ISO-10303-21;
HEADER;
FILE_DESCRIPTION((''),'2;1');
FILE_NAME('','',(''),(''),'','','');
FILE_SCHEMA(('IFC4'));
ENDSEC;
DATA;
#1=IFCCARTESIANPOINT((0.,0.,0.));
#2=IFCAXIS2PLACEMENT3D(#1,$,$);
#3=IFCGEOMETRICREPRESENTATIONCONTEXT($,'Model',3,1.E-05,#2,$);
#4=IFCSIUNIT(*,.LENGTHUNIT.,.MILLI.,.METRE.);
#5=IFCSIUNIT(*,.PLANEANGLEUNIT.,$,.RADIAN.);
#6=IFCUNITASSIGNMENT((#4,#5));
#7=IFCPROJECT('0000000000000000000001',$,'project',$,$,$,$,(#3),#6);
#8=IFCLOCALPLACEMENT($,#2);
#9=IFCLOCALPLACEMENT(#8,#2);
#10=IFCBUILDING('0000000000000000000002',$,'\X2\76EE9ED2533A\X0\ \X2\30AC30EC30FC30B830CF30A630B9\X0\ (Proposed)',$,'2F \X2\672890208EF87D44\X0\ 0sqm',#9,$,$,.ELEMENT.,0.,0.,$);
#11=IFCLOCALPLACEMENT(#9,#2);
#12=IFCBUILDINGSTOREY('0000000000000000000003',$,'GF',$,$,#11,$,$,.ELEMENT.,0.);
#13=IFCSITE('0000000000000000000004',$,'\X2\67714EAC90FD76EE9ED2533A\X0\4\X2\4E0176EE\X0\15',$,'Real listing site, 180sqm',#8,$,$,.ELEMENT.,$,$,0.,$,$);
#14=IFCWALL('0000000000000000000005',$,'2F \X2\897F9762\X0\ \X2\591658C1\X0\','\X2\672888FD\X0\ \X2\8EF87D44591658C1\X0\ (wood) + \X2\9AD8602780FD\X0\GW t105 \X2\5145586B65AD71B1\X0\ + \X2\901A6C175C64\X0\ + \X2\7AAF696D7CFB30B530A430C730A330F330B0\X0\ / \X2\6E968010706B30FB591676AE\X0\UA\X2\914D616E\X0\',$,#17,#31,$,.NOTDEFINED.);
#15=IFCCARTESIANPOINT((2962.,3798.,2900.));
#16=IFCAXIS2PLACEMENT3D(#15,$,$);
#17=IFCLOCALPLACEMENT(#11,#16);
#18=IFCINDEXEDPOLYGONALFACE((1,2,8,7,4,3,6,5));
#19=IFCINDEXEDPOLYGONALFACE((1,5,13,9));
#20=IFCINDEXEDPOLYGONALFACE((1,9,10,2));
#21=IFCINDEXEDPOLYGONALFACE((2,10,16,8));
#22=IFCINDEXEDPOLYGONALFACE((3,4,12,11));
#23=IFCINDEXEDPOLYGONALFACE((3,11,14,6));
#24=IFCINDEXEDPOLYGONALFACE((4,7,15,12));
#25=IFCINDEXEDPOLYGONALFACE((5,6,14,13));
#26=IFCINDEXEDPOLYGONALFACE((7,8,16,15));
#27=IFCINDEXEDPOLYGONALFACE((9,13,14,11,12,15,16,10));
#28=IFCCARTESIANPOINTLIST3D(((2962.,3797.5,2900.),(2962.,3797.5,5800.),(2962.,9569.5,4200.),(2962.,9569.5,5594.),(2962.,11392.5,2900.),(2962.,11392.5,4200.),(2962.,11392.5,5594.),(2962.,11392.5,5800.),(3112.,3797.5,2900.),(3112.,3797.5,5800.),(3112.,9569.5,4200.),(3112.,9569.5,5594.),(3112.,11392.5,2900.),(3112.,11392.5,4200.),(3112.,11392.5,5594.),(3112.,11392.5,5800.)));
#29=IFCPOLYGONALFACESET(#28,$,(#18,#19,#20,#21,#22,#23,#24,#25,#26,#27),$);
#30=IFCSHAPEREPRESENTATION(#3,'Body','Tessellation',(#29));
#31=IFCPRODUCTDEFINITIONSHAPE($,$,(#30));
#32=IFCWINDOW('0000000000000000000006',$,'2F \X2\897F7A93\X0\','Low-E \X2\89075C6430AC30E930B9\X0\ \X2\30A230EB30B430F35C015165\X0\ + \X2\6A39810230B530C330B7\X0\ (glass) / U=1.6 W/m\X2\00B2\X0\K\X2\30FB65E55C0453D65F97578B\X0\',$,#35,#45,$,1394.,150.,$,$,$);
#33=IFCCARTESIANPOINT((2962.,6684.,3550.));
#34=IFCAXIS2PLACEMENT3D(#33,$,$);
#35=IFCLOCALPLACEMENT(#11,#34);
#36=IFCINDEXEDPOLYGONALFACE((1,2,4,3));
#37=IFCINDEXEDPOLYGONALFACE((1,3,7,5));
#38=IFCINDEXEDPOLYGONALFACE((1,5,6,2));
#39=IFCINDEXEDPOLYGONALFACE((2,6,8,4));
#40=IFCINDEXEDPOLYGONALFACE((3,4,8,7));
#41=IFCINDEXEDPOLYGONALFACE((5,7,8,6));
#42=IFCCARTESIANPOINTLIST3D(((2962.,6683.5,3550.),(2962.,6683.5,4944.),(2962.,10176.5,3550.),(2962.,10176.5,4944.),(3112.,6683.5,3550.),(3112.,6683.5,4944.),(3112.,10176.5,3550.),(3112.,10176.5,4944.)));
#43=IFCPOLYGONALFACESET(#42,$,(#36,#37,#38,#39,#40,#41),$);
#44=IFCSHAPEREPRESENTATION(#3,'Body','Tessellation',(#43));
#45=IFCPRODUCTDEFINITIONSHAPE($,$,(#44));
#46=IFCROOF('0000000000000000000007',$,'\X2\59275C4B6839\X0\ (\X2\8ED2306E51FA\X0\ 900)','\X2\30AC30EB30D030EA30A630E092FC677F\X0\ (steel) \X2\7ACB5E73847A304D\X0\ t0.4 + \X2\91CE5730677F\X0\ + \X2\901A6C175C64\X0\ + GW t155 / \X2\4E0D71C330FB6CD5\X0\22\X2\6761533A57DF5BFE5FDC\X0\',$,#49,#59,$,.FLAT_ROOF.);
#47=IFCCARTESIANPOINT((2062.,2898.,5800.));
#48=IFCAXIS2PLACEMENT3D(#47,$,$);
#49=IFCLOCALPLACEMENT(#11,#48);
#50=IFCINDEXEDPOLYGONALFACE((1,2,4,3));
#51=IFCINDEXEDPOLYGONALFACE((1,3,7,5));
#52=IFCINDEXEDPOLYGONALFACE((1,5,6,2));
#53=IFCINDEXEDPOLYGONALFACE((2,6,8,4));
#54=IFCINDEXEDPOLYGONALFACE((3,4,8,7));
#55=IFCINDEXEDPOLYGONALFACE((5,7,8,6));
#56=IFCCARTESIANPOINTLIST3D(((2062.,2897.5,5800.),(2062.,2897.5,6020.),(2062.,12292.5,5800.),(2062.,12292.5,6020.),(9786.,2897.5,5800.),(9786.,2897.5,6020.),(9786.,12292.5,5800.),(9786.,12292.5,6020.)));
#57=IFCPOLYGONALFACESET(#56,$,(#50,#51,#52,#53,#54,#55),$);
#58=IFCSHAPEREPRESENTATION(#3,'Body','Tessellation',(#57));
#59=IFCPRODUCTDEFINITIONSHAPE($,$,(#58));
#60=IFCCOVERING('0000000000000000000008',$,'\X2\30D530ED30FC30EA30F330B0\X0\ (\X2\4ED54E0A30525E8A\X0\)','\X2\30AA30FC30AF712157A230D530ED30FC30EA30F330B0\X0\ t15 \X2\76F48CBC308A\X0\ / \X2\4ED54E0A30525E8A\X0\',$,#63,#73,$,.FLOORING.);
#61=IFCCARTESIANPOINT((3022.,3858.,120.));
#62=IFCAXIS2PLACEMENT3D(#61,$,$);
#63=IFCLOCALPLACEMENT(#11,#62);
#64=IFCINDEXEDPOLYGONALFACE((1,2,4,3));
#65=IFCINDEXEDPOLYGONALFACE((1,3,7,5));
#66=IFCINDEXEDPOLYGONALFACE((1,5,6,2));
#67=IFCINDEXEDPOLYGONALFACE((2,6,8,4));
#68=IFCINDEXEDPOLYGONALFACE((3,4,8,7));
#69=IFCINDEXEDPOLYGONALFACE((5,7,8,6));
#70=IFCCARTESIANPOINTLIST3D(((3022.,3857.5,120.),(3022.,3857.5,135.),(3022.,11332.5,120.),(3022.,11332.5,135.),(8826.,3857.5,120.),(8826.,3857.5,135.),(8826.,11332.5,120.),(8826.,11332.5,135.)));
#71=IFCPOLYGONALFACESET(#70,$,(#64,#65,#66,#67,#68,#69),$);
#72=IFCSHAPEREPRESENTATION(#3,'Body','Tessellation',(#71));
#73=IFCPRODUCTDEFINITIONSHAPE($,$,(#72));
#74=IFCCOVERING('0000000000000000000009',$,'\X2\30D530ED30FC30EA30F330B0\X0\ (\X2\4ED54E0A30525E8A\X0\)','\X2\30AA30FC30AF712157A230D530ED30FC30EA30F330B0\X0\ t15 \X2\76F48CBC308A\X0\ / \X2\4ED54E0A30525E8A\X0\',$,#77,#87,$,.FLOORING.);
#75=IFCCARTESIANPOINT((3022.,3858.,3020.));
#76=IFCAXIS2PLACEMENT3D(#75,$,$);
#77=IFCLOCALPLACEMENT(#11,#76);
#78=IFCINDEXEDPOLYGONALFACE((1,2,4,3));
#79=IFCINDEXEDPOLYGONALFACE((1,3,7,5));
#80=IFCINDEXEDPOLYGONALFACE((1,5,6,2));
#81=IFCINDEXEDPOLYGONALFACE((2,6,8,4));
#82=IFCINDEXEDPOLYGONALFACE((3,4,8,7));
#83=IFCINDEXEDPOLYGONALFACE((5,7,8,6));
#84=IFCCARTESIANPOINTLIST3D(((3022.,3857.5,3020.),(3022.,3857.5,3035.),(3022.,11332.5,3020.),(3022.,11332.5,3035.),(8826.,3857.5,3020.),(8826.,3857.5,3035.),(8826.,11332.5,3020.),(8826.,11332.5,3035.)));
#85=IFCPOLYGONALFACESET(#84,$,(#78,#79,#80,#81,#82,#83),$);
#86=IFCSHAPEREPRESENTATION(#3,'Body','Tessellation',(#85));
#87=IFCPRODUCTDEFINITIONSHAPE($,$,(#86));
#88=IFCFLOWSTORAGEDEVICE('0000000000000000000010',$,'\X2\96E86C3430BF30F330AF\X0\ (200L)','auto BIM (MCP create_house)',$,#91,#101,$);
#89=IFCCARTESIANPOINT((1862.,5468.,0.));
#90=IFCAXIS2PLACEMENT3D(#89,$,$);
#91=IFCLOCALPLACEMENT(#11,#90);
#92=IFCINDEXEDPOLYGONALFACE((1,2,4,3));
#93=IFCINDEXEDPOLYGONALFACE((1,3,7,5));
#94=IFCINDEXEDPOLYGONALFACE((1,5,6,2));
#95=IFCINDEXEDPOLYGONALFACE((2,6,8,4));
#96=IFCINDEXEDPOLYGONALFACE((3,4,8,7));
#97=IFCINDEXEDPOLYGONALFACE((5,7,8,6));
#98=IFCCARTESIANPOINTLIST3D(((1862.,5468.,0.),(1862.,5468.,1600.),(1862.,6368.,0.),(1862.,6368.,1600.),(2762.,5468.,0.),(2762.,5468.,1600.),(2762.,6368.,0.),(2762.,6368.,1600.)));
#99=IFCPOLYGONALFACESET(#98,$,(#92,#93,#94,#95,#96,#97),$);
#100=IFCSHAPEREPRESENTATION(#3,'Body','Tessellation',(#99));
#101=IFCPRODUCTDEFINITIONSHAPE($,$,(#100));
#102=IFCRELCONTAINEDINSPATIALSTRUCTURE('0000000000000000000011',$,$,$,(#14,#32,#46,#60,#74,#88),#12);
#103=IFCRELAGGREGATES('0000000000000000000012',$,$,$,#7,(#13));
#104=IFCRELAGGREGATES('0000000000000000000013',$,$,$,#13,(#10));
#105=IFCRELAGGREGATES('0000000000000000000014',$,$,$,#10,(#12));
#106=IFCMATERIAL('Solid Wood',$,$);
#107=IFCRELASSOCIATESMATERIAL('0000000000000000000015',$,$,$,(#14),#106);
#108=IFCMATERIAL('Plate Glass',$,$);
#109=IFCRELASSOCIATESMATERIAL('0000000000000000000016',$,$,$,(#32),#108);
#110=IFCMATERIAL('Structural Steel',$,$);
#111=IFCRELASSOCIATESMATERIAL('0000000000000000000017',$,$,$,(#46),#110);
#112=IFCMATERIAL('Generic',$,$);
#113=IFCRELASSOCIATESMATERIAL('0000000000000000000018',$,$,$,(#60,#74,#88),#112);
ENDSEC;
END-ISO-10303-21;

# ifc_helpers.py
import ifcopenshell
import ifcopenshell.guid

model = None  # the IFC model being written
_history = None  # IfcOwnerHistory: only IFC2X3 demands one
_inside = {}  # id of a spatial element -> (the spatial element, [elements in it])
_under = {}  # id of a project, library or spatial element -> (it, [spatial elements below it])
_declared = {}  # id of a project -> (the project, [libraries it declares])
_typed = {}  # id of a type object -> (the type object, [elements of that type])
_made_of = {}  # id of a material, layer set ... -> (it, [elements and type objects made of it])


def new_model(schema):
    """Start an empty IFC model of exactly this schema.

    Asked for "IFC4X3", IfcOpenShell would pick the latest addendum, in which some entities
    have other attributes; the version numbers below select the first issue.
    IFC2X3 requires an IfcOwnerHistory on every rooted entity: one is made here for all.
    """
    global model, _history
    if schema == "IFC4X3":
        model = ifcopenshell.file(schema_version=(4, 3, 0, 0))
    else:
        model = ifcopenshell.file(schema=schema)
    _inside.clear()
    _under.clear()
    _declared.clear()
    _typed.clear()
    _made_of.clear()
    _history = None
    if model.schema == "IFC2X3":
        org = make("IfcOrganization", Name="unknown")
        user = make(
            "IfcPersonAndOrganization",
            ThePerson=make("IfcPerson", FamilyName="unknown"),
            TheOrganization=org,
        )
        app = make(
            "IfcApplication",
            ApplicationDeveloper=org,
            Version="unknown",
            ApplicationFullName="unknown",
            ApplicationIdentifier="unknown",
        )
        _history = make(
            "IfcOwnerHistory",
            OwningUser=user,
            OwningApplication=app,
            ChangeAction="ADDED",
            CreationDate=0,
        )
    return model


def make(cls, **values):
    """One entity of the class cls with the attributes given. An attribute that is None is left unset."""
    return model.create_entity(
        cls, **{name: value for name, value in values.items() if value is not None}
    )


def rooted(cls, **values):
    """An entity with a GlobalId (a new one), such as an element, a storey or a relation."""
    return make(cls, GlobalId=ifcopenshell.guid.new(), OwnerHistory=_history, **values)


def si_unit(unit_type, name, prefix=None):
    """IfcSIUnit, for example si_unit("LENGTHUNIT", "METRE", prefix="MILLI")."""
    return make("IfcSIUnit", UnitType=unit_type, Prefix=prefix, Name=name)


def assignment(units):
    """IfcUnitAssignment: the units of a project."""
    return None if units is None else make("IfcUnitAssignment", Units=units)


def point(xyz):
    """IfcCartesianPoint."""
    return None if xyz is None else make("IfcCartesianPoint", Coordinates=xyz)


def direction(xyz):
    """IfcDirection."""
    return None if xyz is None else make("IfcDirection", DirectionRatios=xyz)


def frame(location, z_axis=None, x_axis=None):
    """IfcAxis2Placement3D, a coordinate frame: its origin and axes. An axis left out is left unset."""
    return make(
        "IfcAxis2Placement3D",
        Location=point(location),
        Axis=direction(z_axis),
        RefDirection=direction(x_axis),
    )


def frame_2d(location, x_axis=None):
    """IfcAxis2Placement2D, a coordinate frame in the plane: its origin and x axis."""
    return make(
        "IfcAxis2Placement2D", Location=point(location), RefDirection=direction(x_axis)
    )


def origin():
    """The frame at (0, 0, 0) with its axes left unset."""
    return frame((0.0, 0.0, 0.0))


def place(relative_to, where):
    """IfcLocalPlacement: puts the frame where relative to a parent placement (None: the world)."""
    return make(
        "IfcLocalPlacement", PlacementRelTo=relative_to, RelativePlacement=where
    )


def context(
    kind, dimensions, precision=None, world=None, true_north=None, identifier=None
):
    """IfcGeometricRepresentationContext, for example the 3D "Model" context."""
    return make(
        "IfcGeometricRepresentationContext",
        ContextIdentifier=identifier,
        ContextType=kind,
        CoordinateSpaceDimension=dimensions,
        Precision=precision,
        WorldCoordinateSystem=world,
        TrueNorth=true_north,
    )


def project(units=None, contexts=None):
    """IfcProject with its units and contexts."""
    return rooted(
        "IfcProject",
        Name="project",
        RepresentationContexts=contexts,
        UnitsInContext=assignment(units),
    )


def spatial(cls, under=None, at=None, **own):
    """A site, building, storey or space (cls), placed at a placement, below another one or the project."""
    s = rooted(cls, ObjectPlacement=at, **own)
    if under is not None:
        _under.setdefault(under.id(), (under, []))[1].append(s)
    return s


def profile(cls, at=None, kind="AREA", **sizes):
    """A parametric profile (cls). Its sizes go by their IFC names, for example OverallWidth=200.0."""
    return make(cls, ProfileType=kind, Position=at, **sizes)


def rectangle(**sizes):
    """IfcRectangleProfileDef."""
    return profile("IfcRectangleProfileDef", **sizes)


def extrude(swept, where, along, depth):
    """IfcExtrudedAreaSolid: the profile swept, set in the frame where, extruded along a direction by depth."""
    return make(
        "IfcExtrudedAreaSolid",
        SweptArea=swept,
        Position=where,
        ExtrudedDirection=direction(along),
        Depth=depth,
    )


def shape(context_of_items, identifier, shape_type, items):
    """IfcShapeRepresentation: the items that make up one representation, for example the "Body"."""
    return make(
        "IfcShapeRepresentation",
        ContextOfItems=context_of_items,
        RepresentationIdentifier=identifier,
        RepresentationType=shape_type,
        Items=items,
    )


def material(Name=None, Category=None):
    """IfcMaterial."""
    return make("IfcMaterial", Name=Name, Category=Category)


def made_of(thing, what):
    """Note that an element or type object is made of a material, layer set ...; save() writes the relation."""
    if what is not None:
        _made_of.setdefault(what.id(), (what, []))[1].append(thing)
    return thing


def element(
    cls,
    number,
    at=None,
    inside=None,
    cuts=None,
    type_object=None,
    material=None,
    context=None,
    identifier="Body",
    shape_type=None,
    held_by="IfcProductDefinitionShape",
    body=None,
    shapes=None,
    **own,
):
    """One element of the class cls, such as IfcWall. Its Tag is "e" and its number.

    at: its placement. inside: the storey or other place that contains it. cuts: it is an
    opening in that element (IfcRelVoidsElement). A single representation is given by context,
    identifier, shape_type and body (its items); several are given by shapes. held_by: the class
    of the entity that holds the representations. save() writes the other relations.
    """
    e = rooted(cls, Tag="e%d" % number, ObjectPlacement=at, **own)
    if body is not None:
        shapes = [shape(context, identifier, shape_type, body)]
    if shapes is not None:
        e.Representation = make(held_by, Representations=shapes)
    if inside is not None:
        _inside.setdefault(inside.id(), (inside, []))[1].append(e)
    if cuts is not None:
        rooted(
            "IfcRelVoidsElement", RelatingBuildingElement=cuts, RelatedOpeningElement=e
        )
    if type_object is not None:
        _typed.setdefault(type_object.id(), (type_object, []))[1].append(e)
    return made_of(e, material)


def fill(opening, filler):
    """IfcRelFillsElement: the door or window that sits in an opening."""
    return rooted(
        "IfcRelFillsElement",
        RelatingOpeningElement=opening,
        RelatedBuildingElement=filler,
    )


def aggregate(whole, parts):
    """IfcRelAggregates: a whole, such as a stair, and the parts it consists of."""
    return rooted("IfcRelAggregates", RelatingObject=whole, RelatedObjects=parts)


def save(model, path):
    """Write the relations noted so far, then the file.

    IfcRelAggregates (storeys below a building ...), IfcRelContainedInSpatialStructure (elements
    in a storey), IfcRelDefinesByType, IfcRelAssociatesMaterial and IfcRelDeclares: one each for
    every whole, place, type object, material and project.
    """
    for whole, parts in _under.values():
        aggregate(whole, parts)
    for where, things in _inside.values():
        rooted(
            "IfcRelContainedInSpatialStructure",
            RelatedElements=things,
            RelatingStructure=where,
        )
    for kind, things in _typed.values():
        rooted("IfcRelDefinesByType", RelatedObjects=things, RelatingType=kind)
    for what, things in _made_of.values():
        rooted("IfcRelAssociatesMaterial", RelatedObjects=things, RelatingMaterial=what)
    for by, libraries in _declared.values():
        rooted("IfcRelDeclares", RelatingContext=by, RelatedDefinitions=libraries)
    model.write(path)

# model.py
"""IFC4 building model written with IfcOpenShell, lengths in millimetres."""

from ifc_helpers import new_model, si_unit, frame, frame_2d, origin, place, context, project, spatial, rectangle, extrude, material, element, fill, save


model = new_model("IFC4")

# Units and contexts
model_context = context("Model", 3, precision=1e-05, world=origin())
ifc_project = project(units=[si_unit("LENGTHUNIT", "METRE", prefix="MILLI"), si_unit("PLANEANGLEUNIT", "RADIAN")], contexts=[model_context])

# Site, building, storey
site_placement = place(None, origin())
site = spatial("IfcSite", under=ifc_project, at=site_placement, Name="東京都目黒区4丁目15", ObjectType="Real listing site, 180sqm", CompositionType="ELEMENT", RefElevation=0.0)
building_placement = place(site_placement, origin())
building = spatial("IfcBuilding", under=site, at=building_placement, Name="目黒区 ガレージハウス (Proposed)", ObjectType="2F 木造軸組 0sqm", CompositionType="ELEMENT", ElevationOfRefHeight=0.0, ElevationOfTerrain=0.0)
storey_placement = place(building_placement, origin())
storey = spatial("IfcBuildingStorey", under=building, at=storey_placement, Name="GF", CompositionType="ELEMENT", Elevation=0.0)

# Shared definitions
ifc_material_1 = material(Name="Solid Wood")

# Shared definitions
ifc_material_2 = material(Name="Plate Glass")

# Wall, opening, window
wall_1_placement = place(storey_placement, frame((2962.0, 3798.0, 2900.0)))
wall_1 = element("IfcWall", 1, at=wall_1_placement, inside=storey, material=ifc_material_1, Name="2F 西面 外壁", Description="木製 軸組外壁 (wood) + 高性能GW t105 充填断熱 + 通気層 + 窯業系サイディング / 準耐火・外皮UA配慮", PredefinedType="NOTDEFINED", context=model_context, shape_type="SweptSolid", body=[
    extrude(rectangle(XDim=150.0, YDim=7595.0, at=frame_2d((75.0, 3797.0))), frame((2962.0, 3798.0, 2900.0)), (0.0, 0.0, 1.0), 2900.0),
])
opening_1_placement = place(storey_placement, frame((2962.0, 6684.0, 3550.0)))
opening_1 = element("IfcOpeningElement", 2, at=opening_1_placement, cuts=wall_1, PredefinedType="NOTDEFINED", context=model_context, shape_type="SweptSolid", body=[
    extrude(rectangle(XDim=150.0, YDim=3493.0, at=frame_2d((75.0, 1746.0))), frame((2962.0, 6684.0, 3550.0)), (0.0, 0.0, 1.0), 1394.0),
])
window_1_placement = place(storey_placement, frame((2962.0, 6684.0, 3550.0)))
window_1 = element("IfcWindow", 3, at=window_1_placement, inside=storey, material=ifc_material_2, Name="2F 西窓", Description="Low-E 複層ガラス アルゴン封入 + 樹脂サッシ (glass) / U=1.6 W/m²K・日射取得型", OverallHeight=1394.0, OverallWidth=150.0, context=model_context, shape_type="SweptSolid", body=[
    extrude(rectangle(XDim=150.0, YDim=3493.0, at=frame_2d((75.0, 1746.0))), frame((2962.0, 6684.0, 3550.0)), (0.0, 0.0, 1.0), 1394.0),
])
fill(opening_1, window_1)

# Roof
ifc_material_3 = material(Name="Structural Steel")
roof_placement = place(storey_placement, frame((2062.0, 2898.0, 5800.0)))
element("IfcRoof", 4, at=roof_placement, inside=storey, material=ifc_material_3, Name="大屋根 (軒の出 900)", Description="ガルバリウム鋼板 (steel) 立平葺き t0.4 + 野地板 + 通気層 + GW t155 / 不燃・法22条区域対応", PredefinedType="FLAT_ROOF", context=model_context, shape_type="SweptSolid", body=[
    extrude(rectangle(XDim=7724.0, YDim=9395.0, at=frame_2d((3862.0, 4697.0))), frame((2062.0, 2898.0, 5800.0)), (0.0, 0.0, 1.0), 220.0),
])

# Coverings
ifc_material_4 = material(Name="Generic")
covering_1_placement = place(storey_placement, frame((3022.0, 3858.0, 120.0)))
element("IfcCovering", 5, at=covering_1_placement, inside=storey, material=ifc_material_4, Name="フローリング (仕上げ床)", Description="オーク無垢フローリング t15 直貼り / 仕上げ床", PredefinedType="FLOORING", context=model_context, shape_type="SweptSolid", body=[
    extrude(rectangle(XDim=5804.0, YDim=7475.0, at=frame_2d((2902.0, 3737.0))), frame((3022.0, 3858.0, 120.0)), (0.0, 0.0, 1.0), 15.0),
])
covering_2_placement = place(storey_placement, frame((3022.0, 3858.0, 3020.0)))
element("IfcCovering", 6, at=covering_2_placement, inside=storey, material=ifc_material_4, Name="フローリング (仕上げ床)", Description="オーク無垢フローリング t15 直貼り / 仕上げ床", PredefinedType="FLOORING", context=model_context, shape_type="SweptSolid", body=[
    extrude(rectangle(XDim=5804.0, YDim=7475.0, at=frame_2d((2902.0, 3737.0))), frame((3022.0, 3858.0, 3020.0)), (0.0, 0.0, 1.0), 15.0),
])

# Flow storage device
flow_storage_device_placement = place(storey_placement, frame((1862.0, 5468.0, 0.0)))
element("IfcFlowStorageDevice", 7, at=flow_storage_device_placement, inside=storey, material=ifc_material_4, Name="雨水タンク (200L)", Description="auto BIM (MCP create_house)", context=model_context, shape_type="SweptSolid", body=[
    extrude(rectangle(XDim=900.0, YDim=900.0, at=frame_2d((450.0, 450.0))), frame((1862.0, 5468.0, 0.0)), (0.0, 0.0, 1.0), 1600.0),
])

save(model, "model.ifc")
